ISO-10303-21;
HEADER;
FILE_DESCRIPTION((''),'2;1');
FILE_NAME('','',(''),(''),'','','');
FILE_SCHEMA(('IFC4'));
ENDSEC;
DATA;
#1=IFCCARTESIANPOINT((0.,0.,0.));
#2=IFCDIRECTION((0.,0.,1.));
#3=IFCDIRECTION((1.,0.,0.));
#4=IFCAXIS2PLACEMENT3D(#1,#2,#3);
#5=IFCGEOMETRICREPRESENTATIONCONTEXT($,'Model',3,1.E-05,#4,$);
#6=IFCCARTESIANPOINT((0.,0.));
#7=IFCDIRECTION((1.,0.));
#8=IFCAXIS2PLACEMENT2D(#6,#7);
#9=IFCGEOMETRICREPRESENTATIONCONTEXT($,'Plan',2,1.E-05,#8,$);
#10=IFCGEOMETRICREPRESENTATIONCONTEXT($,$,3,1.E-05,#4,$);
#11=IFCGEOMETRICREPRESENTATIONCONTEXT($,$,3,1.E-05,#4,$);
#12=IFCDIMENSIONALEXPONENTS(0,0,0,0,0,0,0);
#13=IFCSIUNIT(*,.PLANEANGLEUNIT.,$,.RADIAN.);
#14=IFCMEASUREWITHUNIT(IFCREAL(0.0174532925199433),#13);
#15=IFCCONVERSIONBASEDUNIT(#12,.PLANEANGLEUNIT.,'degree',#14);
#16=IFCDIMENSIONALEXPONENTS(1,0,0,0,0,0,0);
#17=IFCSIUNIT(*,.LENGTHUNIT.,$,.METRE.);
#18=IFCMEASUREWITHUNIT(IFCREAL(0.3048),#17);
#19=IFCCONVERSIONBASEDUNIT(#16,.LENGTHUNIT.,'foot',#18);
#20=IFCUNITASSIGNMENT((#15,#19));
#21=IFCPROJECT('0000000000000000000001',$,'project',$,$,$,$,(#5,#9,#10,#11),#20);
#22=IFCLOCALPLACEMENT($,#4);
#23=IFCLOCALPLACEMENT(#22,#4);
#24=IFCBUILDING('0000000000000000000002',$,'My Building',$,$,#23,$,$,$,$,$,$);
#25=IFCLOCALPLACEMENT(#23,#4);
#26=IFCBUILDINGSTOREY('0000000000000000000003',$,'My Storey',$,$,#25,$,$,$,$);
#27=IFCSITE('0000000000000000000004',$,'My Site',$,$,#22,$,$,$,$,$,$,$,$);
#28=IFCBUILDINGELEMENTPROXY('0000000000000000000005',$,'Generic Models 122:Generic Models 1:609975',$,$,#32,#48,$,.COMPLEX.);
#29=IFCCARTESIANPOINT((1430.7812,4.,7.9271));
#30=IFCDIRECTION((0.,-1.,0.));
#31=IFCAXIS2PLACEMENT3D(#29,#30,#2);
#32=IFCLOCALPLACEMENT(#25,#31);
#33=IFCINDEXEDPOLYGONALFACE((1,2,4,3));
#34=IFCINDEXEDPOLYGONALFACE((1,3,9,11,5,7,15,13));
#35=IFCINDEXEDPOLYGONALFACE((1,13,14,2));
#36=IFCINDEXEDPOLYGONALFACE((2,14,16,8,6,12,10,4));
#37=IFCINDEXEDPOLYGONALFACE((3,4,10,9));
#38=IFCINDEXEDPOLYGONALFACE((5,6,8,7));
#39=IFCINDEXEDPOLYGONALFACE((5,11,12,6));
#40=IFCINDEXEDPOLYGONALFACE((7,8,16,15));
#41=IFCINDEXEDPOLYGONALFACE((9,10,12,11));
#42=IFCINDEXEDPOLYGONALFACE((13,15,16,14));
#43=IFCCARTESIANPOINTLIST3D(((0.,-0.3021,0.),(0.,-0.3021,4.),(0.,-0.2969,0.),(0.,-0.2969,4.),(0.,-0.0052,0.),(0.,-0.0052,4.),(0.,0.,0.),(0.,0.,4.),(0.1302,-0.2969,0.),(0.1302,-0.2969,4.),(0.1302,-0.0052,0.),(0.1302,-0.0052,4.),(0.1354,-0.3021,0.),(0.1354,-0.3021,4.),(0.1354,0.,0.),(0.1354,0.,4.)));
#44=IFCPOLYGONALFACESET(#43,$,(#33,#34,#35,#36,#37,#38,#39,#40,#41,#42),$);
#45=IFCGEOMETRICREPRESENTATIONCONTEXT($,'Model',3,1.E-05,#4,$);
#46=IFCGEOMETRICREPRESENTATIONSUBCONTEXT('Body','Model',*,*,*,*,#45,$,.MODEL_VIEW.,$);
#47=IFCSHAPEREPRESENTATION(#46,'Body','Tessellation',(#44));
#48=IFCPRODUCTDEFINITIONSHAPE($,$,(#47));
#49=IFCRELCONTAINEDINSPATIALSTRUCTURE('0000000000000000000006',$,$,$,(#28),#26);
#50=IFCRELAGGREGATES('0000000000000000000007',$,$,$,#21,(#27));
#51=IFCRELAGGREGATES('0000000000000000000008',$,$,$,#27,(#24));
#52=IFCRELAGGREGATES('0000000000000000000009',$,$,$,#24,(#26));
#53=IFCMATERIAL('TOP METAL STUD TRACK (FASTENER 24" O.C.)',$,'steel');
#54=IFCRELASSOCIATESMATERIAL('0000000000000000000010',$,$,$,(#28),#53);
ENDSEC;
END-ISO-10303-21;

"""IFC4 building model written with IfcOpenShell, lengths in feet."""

from ifc_helpers import new_model, entity, si_unit, converted_unit, frame, origin_with_axes, origin_2d_with_axis, place, context, subcontext, project, spatial, line, indexed_curve, outline, extrude, material, element, save


model = new_model("IFC4")

# Units and contexts
model_context_1 = context("Model", 3, precision=1e-05, world=origin_with_axes())
plan_context = context("Plan", 2, precision=1e-05, world=origin_2d_with_axis())
model_context_2 = context("Model", 3, precision=1e-05, world=origin_with_axes())
context_of_model_1 = context(None, 3, precision=1e-05, world=origin_with_axes())
context_of_model_2 = context(None, 3, precision=1e-05, world=origin_with_axes())
body_context = subcontext(model_context_2, "Body", "Model", "MODEL_VIEW")
ifc_project = project(units=[converted_unit("PLANEANGLEUNIT", "degree", entity("IfcReal", 0.0174532925199433), si_unit("PLANEANGLEUNIT", "RADIAN"), dimensions=[0, 0, 0, 0, 0, 0, 0]), converted_unit("LENGTHUNIT", "foot", entity("IfcReal", 0.3048), si_unit("LENGTHUNIT", "METRE"), dimensions=[1, 0, 0, 0, 0, 0, 0])], contexts=[model_context_1, plan_context, context_of_model_1, context_of_model_2])

# Site, building, storey
site_placement = place(None, origin_with_axes())
site = spatial("IfcSite", under=ifc_project, at=site_placement, Name="My Site")
building_placement = place(site_placement, origin_with_axes())
building = spatial("IfcBuilding", under=site, at=building_placement, Name="My Building")
storey_placement = place(building_placement, origin_with_axes())
storey = spatial("IfcBuildingStorey", under=building, at=storey_placement, Name="My Storey")

# Building element proxy
ifc_material_1 = material(Name="TOP METAL STUD TRACK (FASTENER 24\" O.C.)", Category="steel")
proxy_1_placement = place(storey_placement, frame((1430.7812, 4.0, 7.9271), z_axis=(0.0, -1.0, 0.0), x_axis=(0.0, 0.0, 1.0)))
element("IfcBuildingElementProxy", 1, at=proxy_1_placement, inside=storey, material=ifc_material_1, Name="Generic Models 122:Generic Models 1:609975", PredefinedType="COMPLEX", context=body_context, shape_type="SweptSolid", body=[
    extrude(outline(indexed_curve([(-0.069, -0.151), (0.0664, -0.151), (0.0664, -0.1458), (-0.0638, -0.1458), (-0.0638, 0.1458), (0.0664, 0.1458), (0.0664, 0.151), (-0.069, 0.151)], segments=[line(5, 6), line(6, 7), line(7, 8), line(8, 1), line(1, 2), line(2, 3), line(3, 4), line(4, 5)], self_intersect=False)), frame((0.0664, -0.151, 0.0), z_axis=(0.0, 0.0, -1.0), x_axis=(-1.0, 0.0, 0.0)), (0.0, 0.0, -1.0), 4.0),
])

save(model, "model.ifc")
